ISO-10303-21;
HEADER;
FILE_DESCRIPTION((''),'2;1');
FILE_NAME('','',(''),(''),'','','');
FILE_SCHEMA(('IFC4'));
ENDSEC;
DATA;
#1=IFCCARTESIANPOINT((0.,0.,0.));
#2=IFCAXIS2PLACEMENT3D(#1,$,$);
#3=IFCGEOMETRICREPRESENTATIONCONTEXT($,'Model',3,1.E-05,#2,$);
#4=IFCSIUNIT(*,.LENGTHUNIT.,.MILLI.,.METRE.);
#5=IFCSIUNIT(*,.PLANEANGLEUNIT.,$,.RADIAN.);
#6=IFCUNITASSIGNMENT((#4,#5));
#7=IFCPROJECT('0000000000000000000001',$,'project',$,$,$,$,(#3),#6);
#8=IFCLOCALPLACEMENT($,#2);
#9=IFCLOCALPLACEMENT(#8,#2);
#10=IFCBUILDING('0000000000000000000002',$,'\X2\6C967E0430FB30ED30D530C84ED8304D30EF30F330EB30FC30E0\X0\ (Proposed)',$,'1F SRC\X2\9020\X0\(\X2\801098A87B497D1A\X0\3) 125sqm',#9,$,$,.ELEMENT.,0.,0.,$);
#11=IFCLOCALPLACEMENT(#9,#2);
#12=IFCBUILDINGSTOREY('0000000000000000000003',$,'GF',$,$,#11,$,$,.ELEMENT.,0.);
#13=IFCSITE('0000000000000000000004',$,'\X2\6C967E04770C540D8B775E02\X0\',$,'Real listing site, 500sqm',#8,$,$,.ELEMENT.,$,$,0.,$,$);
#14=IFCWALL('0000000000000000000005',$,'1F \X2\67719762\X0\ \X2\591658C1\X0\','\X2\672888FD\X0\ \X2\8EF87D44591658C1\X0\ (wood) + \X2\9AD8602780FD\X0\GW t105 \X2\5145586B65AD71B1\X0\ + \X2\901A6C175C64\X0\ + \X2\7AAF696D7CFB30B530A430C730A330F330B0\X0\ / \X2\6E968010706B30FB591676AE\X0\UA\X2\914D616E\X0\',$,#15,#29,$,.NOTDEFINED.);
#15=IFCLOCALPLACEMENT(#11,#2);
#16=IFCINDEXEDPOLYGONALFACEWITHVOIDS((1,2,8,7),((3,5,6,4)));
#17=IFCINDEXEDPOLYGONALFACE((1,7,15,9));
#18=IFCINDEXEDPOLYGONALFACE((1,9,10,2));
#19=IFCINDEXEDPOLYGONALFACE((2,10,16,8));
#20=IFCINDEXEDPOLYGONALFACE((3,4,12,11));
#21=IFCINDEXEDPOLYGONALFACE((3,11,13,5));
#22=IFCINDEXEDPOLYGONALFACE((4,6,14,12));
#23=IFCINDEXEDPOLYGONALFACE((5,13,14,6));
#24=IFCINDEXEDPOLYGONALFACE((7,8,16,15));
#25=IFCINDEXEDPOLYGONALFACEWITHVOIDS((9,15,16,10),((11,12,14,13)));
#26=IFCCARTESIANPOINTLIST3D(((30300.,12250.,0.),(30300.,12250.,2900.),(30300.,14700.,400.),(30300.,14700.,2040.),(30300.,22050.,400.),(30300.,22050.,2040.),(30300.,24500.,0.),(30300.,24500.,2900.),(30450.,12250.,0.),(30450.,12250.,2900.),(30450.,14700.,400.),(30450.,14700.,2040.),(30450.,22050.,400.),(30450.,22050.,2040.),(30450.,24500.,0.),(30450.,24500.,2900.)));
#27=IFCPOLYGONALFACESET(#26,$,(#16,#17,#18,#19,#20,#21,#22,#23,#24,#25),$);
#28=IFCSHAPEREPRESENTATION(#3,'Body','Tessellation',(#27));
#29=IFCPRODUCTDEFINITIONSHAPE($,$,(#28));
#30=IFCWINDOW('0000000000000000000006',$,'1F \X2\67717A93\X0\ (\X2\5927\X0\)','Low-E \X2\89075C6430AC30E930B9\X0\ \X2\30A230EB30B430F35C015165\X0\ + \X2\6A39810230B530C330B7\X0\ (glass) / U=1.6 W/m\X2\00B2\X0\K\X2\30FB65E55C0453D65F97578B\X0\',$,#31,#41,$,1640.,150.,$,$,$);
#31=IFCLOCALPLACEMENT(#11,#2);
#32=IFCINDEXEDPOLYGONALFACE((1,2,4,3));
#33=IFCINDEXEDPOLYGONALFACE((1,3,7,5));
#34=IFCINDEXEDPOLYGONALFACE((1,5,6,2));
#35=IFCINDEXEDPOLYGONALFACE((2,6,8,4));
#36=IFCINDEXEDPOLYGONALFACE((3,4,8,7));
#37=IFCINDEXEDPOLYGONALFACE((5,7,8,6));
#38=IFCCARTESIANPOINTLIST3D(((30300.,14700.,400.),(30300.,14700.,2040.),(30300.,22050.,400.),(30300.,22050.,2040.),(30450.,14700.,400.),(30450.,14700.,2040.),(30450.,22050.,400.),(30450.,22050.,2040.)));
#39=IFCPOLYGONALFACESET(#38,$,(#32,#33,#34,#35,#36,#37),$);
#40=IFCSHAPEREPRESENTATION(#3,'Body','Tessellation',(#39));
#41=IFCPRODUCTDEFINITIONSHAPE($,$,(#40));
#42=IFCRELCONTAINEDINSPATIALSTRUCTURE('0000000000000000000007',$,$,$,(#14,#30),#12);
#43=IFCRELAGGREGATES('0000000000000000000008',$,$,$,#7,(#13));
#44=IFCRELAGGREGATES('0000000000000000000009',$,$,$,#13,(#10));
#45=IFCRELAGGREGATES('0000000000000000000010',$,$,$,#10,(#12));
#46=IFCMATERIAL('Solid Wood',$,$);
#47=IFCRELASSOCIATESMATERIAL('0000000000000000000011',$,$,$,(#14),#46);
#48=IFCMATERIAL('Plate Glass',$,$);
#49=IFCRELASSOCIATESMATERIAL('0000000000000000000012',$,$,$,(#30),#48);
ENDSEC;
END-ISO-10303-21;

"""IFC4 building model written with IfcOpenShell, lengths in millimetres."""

from ifc_helpers import new_model, si_unit, frame, frame_2d, origin, place, context, project, spatial, rectangle, extrude, material, element, fill, save


model = new_model("IFC4")

# Units and contexts
model_context = context("Model", 3, precision=1e-05, world=origin())
ifc_project = project(units=[si_unit("LENGTHUNIT", "METRE", prefix="MILLI"), si_unit("PLANEANGLEUNIT", "RADIAN")], contexts=[model_context])

# Site, building, storey
site_placement = place(None, origin())
site = spatial("IfcSite", under=ifc_project, at=site_placement, Name="沖縄県名護市", ObjectType="Real listing site, 500sqm", CompositionType="ELEMENT", RefElevation=0.0)
building_placement = place(site_placement, origin())
building = spatial("IfcBuilding", under=site, at=building_placement, Name="沖縄・ロフト付きワンルーム (Proposed)", ObjectType="1F SRC造(耐風等級3) 125sqm", CompositionType="ELEMENT", ElevationOfRefHeight=0.0, ElevationOfTerrain=0.0)
storey_placement = place(building_placement, origin())
storey = spatial("IfcBuildingStorey", under=building, at=storey_placement, Name="GF", CompositionType="ELEMENT", Elevation=0.0)

# Shared definitions
ifc_material_1 = material(Name="Solid Wood")

# Wall, opening, window
wall_1_placement = place(storey_placement, frame((15150.0, 6125.0, 0.0)))
wall_1 = element("IfcWall", 1, at=wall_1_placement, inside=storey, material=ifc_material_1, Name="1F 東面 外壁", Description="木製 軸組外壁 (wood) + 高性能GW t105 充填断熱 + 通気層 + 窯業系サイディング / 準耐火・外皮UA配慮", PredefinedType="NOTDEFINED", context=model_context, shape_type="SweptSolid", body=[
    extrude(rectangle(XDim=150.0, YDim=12250.0, at=frame_2d((75.0, 6125.0))), frame((15150.0, 6125.0, 0.0)), (0.0, 0.0, 1.0), 2900.0),
])
opening_placement = place(storey_placement, frame((15150.0, 7350.0, 200.0)))
opening = element("IfcOpeningElement", 2, at=opening_placement, cuts=wall_1, PredefinedType="NOTDEFINED", context=model_context, shape_type="SweptSolid", body=[
    extrude(rectangle(XDim=150.0, YDim=7350.0, at=frame_2d((75.0, 3675.0))), frame((15150.0, 7350.0, 200.0)), (0.0, 0.0, 1.0), 1640.0),
])
ifc_material_2 = material(Name="Plate Glass")
window_placement = place(storey_placement, frame((15150.0, 7350.0, 200.0)))
window = element("IfcWindow", 3, at=window_placement, inside=storey, material=ifc_material_2, Name="1F 東窓 (大)", Description="Low-E 複層ガラス アルゴン封入 + 樹脂サッシ (glass) / U=1.6 W/m²K・日射取得型", OverallHeight=1640.0, OverallWidth=150.0, context=model_context, shape_type="SweptSolid", body=[
    extrude(rectangle(XDim=150.0, YDim=7350.0, at=frame_2d((75.0, 3675.0))), frame((15150.0, 7350.0, 200.0)), (0.0, 0.0, 1.0), 1640.0),
])
fill(opening, window)

save(model, "model.ifc")
